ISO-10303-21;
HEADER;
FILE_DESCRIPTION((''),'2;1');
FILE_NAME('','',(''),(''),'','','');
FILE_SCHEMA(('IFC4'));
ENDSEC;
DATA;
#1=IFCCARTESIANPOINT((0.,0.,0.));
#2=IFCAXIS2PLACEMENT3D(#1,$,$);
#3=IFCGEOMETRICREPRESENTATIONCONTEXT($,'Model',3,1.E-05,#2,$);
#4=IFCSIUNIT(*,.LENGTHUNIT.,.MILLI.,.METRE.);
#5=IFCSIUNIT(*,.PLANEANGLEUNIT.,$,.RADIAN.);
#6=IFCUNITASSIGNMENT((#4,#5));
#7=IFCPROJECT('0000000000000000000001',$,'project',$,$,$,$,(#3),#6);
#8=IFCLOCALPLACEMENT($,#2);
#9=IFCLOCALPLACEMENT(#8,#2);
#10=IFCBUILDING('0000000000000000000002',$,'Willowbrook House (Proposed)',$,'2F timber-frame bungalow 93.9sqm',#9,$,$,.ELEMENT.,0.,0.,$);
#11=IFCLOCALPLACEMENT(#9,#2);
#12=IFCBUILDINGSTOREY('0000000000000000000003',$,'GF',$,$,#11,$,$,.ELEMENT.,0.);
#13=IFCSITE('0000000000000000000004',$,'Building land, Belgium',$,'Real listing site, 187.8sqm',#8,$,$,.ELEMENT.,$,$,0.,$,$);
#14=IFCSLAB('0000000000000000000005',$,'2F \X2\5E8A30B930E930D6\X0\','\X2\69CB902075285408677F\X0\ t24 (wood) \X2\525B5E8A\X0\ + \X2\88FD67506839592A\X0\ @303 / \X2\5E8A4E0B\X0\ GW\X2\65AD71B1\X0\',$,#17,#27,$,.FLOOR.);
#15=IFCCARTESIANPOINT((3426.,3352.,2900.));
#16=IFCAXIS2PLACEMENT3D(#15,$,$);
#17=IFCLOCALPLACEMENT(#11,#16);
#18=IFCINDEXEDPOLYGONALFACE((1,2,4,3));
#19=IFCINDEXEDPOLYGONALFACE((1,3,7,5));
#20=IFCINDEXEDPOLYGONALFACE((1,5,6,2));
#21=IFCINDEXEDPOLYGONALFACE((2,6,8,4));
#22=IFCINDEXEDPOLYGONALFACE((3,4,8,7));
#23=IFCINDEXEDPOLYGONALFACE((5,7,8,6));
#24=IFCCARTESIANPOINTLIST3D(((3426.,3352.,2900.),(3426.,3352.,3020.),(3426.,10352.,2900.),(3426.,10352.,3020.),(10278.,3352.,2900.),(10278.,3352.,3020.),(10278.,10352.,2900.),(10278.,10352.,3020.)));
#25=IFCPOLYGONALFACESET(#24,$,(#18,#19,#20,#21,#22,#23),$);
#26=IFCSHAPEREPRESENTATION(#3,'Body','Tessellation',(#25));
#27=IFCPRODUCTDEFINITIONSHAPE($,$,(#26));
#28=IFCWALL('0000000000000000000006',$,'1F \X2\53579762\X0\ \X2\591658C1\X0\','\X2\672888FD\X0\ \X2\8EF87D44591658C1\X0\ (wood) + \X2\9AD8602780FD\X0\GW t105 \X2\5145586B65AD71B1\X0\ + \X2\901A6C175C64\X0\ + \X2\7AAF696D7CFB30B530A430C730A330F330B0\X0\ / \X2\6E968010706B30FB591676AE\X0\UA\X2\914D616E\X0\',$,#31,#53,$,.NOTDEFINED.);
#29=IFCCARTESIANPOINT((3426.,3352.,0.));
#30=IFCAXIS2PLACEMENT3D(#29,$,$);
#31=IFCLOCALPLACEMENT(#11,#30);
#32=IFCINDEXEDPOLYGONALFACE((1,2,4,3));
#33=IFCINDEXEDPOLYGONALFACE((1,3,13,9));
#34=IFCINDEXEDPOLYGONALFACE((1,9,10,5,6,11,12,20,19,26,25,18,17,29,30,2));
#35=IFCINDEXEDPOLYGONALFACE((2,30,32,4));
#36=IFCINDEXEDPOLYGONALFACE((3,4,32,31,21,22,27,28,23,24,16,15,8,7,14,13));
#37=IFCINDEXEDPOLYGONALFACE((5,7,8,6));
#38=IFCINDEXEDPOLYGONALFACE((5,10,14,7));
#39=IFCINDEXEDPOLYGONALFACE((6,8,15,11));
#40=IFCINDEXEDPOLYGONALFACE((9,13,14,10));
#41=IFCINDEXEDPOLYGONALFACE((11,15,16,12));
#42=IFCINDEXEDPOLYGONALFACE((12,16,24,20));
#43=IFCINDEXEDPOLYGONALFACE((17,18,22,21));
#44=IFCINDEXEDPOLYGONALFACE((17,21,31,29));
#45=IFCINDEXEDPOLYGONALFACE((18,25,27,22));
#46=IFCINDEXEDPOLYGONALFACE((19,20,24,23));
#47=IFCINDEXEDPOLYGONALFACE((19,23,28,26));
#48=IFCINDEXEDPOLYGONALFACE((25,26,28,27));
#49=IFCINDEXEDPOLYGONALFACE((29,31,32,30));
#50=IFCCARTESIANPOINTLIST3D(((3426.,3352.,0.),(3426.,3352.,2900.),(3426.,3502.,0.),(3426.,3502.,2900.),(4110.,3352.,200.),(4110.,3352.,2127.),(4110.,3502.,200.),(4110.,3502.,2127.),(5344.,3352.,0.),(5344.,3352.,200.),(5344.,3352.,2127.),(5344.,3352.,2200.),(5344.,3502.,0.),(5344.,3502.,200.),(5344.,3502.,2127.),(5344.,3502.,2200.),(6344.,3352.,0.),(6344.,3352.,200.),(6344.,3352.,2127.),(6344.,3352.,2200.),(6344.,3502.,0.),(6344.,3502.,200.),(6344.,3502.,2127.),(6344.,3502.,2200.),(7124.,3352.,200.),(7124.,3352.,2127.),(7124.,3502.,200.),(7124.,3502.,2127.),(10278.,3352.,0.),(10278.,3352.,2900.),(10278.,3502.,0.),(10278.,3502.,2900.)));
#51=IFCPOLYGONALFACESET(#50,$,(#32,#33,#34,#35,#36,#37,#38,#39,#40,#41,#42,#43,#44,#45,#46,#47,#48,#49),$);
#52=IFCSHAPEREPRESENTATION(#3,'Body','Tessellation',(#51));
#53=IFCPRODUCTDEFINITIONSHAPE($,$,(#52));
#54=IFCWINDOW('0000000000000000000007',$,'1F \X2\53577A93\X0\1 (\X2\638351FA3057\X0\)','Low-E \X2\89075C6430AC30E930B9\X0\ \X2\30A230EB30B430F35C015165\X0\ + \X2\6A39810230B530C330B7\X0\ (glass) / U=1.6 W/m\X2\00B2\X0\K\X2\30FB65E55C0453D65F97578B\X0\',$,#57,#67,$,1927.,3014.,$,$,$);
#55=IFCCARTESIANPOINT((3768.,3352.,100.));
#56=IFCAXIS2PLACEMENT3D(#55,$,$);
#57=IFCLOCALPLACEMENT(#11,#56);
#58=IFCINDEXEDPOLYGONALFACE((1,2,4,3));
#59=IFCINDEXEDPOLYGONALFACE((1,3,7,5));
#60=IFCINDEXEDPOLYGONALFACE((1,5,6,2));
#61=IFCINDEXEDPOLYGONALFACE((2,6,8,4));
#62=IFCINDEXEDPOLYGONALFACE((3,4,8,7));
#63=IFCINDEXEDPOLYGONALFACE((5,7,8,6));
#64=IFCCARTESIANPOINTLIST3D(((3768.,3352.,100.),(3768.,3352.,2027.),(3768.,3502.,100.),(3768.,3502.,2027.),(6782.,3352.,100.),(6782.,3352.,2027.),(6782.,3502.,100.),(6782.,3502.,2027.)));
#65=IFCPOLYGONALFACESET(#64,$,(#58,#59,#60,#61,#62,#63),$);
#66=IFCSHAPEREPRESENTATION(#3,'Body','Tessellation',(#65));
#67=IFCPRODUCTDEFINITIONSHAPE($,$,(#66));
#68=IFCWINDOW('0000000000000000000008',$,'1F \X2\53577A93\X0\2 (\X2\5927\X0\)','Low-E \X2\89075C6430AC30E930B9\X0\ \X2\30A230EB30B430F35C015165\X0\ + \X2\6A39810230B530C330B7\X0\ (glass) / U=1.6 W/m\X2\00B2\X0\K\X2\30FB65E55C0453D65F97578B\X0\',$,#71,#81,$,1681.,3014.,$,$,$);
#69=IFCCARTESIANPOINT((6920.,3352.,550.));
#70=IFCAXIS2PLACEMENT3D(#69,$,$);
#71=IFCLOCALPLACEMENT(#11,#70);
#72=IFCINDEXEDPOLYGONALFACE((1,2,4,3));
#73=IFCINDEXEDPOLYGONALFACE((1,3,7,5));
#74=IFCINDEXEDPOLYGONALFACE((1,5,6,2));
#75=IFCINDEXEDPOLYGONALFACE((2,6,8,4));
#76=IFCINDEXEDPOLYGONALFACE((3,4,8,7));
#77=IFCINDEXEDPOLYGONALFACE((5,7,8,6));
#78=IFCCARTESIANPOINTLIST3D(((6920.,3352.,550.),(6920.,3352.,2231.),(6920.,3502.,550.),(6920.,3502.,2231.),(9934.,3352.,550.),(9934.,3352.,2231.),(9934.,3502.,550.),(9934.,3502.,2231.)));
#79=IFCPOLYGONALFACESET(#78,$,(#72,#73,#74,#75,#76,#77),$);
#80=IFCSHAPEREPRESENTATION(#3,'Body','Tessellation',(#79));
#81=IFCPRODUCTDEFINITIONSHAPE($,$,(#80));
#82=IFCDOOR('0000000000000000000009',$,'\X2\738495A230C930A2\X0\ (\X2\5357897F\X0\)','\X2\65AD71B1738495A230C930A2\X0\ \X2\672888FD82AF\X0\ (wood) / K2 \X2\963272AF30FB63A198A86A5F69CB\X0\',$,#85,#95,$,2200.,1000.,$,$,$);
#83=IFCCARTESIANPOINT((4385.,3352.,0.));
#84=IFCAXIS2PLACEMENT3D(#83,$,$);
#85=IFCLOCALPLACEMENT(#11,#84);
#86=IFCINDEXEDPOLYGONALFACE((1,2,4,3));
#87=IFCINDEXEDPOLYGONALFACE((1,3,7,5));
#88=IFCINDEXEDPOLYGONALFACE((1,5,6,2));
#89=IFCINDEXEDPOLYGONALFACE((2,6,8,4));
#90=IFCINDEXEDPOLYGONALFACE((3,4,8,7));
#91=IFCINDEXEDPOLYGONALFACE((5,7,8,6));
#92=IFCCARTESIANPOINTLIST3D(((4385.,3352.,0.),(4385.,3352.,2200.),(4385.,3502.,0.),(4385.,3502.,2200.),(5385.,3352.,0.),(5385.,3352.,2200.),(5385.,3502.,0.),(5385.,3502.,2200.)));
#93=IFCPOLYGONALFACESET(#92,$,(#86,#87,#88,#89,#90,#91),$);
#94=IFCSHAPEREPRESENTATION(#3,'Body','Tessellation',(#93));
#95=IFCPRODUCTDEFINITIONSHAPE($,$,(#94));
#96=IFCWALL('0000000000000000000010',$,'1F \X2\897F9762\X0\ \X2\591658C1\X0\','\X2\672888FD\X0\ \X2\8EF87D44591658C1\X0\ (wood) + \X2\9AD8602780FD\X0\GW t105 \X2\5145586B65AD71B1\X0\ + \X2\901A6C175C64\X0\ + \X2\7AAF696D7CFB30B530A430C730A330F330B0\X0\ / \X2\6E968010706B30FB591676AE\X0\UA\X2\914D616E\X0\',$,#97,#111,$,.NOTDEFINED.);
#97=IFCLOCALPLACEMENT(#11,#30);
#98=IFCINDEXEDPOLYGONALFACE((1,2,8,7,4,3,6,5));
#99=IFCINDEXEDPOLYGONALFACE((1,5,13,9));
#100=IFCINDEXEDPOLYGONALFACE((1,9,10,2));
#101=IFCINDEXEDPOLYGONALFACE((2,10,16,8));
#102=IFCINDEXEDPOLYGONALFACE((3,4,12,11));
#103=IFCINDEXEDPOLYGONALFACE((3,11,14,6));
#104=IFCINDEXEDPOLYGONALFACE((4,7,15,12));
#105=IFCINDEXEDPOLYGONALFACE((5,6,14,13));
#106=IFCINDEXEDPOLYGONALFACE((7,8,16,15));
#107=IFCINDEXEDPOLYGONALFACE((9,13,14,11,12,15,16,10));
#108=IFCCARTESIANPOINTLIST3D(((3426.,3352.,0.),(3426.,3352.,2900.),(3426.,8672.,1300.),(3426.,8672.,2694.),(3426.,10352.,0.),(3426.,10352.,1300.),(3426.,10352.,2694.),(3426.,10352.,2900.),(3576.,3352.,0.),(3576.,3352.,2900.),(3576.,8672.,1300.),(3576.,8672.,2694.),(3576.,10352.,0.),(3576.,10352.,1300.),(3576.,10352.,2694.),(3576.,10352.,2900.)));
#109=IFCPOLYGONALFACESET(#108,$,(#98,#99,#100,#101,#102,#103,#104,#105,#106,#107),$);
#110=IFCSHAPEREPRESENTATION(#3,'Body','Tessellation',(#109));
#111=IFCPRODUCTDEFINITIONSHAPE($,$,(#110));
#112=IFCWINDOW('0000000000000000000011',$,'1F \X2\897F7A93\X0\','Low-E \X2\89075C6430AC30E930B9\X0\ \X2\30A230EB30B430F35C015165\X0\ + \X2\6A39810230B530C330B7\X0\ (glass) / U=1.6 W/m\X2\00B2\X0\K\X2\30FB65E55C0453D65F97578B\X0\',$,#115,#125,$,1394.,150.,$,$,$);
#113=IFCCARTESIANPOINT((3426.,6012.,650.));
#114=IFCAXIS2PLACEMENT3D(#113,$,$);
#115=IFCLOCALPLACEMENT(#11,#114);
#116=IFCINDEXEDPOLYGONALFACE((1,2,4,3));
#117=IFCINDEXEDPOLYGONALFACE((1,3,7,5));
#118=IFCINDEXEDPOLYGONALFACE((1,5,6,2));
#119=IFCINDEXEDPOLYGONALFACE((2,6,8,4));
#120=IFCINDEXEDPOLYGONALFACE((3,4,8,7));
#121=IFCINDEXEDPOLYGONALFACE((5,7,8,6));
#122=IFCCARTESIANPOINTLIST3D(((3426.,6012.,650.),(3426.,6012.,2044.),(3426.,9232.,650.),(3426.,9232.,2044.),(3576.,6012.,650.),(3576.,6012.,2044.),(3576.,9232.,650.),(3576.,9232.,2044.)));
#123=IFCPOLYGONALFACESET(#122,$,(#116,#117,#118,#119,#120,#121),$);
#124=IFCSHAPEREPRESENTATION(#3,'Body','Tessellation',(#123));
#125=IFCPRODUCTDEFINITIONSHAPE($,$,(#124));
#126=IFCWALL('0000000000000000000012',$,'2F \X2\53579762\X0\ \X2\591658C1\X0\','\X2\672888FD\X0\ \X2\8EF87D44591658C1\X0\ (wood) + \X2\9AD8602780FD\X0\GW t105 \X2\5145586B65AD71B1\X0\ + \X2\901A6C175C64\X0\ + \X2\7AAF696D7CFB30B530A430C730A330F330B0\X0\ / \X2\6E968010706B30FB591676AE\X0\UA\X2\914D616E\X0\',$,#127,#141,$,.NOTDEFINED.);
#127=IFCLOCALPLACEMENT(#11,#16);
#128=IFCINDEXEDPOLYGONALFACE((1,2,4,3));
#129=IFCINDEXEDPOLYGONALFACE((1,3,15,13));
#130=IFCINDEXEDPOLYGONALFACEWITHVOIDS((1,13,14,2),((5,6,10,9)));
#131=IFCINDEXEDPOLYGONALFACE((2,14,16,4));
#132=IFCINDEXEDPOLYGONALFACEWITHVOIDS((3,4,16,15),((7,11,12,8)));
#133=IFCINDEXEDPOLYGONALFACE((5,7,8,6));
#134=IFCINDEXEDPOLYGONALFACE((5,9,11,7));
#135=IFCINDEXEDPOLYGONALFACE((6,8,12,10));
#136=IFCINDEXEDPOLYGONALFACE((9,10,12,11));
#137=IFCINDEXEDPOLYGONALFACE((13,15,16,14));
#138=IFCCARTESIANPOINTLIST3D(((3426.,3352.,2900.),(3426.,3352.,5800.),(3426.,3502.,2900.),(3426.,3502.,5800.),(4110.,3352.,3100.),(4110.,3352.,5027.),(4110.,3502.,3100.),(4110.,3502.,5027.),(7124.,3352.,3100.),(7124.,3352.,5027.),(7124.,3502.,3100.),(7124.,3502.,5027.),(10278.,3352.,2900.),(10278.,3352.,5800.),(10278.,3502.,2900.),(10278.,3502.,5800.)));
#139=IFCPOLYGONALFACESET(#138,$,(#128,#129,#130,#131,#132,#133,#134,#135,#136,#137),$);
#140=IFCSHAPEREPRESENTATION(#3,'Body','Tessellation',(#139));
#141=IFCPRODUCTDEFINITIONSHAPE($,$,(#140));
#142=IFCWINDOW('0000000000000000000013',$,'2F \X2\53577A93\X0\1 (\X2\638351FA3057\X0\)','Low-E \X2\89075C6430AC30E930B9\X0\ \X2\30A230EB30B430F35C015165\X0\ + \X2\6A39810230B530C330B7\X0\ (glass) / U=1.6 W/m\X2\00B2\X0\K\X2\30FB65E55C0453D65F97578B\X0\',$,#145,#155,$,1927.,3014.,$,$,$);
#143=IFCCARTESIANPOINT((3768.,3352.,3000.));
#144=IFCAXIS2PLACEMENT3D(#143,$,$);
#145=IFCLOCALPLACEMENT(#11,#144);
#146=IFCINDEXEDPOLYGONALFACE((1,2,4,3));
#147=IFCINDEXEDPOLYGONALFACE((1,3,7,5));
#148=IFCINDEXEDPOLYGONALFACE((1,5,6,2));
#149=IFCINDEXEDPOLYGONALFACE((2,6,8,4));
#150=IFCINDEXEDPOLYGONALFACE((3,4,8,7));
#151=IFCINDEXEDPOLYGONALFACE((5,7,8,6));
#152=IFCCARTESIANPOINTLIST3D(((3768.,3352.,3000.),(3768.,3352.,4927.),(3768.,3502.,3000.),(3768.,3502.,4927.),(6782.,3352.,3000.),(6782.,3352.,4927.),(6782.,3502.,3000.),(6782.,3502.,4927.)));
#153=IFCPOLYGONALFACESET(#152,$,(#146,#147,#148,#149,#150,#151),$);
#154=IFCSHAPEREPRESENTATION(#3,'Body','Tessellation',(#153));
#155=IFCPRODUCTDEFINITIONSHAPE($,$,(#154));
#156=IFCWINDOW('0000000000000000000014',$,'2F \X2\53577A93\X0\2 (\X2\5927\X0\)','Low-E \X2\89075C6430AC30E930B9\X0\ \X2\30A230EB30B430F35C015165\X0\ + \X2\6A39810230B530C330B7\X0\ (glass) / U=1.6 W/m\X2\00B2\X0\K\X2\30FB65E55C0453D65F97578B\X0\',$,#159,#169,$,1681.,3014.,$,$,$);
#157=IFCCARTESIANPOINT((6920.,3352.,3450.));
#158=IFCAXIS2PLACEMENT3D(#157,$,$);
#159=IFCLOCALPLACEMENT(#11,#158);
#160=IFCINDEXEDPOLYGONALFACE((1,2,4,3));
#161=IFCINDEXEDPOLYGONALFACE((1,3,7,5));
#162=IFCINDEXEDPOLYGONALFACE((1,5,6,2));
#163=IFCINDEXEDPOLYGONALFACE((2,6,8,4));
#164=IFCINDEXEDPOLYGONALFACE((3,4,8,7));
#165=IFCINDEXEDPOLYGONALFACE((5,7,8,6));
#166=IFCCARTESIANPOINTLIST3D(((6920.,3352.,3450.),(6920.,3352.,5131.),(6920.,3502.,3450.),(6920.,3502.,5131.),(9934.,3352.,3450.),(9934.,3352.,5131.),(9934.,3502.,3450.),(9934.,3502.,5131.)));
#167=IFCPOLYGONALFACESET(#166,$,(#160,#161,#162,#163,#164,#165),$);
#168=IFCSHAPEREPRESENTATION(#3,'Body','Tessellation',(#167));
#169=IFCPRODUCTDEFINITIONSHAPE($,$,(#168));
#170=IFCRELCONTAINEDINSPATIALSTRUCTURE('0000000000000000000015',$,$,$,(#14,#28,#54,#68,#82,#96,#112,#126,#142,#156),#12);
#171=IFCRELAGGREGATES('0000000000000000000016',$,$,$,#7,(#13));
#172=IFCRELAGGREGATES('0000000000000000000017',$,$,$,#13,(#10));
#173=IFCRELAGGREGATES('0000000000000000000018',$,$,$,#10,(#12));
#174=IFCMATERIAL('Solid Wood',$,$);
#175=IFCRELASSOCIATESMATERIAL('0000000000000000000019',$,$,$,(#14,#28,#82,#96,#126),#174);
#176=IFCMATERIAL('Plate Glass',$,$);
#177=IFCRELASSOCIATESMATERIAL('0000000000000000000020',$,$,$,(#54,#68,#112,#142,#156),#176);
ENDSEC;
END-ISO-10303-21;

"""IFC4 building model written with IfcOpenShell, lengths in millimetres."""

from ifc_helpers import new_model, si_unit, frame, frame_2d, origin, place, context, project, spatial, rectangle, extrude, material, element, fill, save


model = new_model("IFC4")

# Units and contexts
model_context = context("Model", 3, precision=1e-05, world=origin())
ifc_project = project(units=[si_unit("LENGTHUNIT", "METRE", prefix="MILLI"), si_unit("PLANEANGLEUNIT", "RADIAN")], contexts=[model_context])

# Site, building, storey
site_placement = place(None, origin())
site = spatial("IfcSite", under=ifc_project, at=site_placement, Name="Building land, Belgium", ObjectType="Real listing site, 187.8sqm", CompositionType="ELEMENT", RefElevation=0.0)
building_placement = place(site_placement, origin())
building = spatial("IfcBuilding", under=site, at=building_placement, Name="Willowbrook House (Proposed)", ObjectType="2F timber-frame bungalow 93.9sqm", CompositionType="ELEMENT", ElevationOfRefHeight=0.0, ElevationOfTerrain=0.0)
storey_placement = place(building_placement, origin())
storey = spatial("IfcBuildingStorey", under=building, at=storey_placement, Name="GF", CompositionType="ELEMENT", Elevation=0.0)

# Slab
ifc_material_1 = material(Name="Solid Wood")
slab_1_placement = place(storey_placement, frame((3426.0, 3352.0, 2900.0)))
element("IfcSlab", 1, at=slab_1_placement, inside=storey, material=ifc_material_1, Name="2F 床スラブ", Description="構造用合板 t24 (wood) 剛床 + 製材根太 @303 / 床下 GW断熱", PredefinedType="FLOOR", context=model_context, shape_type="SweptSolid", body=[
    extrude(rectangle(XDim=6852.0, YDim=7000.0, at=frame_2d((3426.0, 3500.0))), frame((3426.0, 3352.0, 2900.0)), (0.0, 0.0, 1.0), 120.0),
])

# Wall, openings, windows, door
wall_1_placement = place(storey_placement, frame((3426.0, 3352.0, 0.0)))
wall_1 = element("IfcWall", 2, at=wall_1_placement, inside=storey, material=ifc_material_1, Name="1F 南面 外壁", Description="木製 軸組外壁 (wood) + 高性能GW t105 充填断熱 + 通気層 + 窯業系サイディング / 準耐火・外皮UA配慮", PredefinedType="NOTDEFINED", context=model_context, shape_type="SweptSolid", body=[
    extrude(rectangle(XDim=6852.0, YDim=150.0, at=frame_2d((3426.0, 75.0))), frame((3426.0, 3352.0, 0.0)), (0.0, 0.0, 1.0), 2900.0),
])
opening_1_placement = place(storey_placement, frame((3768.0, 3352.0, 100.0)))
opening_1 = element("IfcOpeningElement", 3, at=opening_1_placement, cuts=wall_1, PredefinedType="NOTDEFINED", context=model_context, shape_type="SweptSolid", body=[
    extrude(rectangle(XDim=3014.0, YDim=150.0, at=frame_2d((1507.0, 75.0))), frame((3768.0, 3352.0, 100.0)), (0.0, 0.0, 1.0), 1927.0),
])
opening_2_placement = place(storey_placement, frame((6920.0, 3352.0, 550.0)))
opening_2 = element("IfcOpeningElement", 4, at=opening_2_placement, cuts=wall_1, PredefinedType="NOTDEFINED", context=model_context, shape_type="SweptSolid", body=[
    extrude(rectangle(XDim=3014.0, YDim=150.0, at=frame_2d((1507.0, 75.0))), frame((6920.0, 3352.0, 550.0)), (0.0, 0.0, 1.0), 1681.0),
])
opening_3_placement = place(storey_placement, frame((4385.0, 3352.0, 0.0)))
opening_3 = element("IfcOpeningElement", 5, at=opening_3_placement, cuts=wall_1, PredefinedType="NOTDEFINED", context=model_context, shape_type="SweptSolid", body=[
    extrude(rectangle(XDim=1000.0, YDim=150.0, at=frame_2d((500.0, 75.0))), frame((4385.0, 3352.0, 0.0)), (0.0, 0.0, 1.0), 2200.0),
])
ifc_material_2 = material(Name="Plate Glass")
window_1_placement = place(storey_placement, frame((3768.0, 3352.0, 100.0)))
window_1 = element("IfcWindow", 6, at=window_1_placement, inside=storey, material=ifc_material_2, Name="1F 南窓1 (掃出し)", Description="Low-E 複層ガラス アルゴン封入 + 樹脂サッシ (glass) / U=1.6 W/m²K・日射取得型", OverallHeight=1927.0, OverallWidth=3014.0, context=model_context, shape_type="SweptSolid", body=[
    extrude(rectangle(XDim=3014.0, YDim=150.0, at=frame_2d((1507.0, 75.0))), frame((3768.0, 3352.0, 100.0)), (0.0, 0.0, 1.0), 1927.0),
])
fill(opening_1, window_1)
window_2_placement = place(storey_placement, frame((6920.0, 3352.0, 550.0)))
window_2 = element("IfcWindow", 7, at=window_2_placement, inside=storey, material=ifc_material_2, Name="1F 南窓2 (大)", Description="Low-E 複層ガラス アルゴン封入 + 樹脂サッシ (glass) / U=1.6 W/m²K・日射取得型", OverallHeight=1681.0, OverallWidth=3014.0, context=model_context, shape_type="SweptSolid", body=[
    extrude(rectangle(XDim=3014.0, YDim=150.0, at=frame_2d((1507.0, 75.0))), frame((6920.0, 3352.0, 550.0)), (0.0, 0.0, 1.0), 1681.0),
])
fill(opening_2, window_2)
door_placement = place(storey_placement, frame((4385.0, 3352.0, 0.0)))
door = element("IfcDoor", 8, at=door_placement, inside=storey, material=ifc_material_1, Name="玄関ドア (南西)", Description="断熱玄関ドア 木製芯 (wood) / K2 防犯・採風機構", OverallHeight=2200.0, OverallWidth=1000.0, context=model_context, shape_type="SweptSolid", body=[
    extrude(rectangle(XDim=1000.0, YDim=150.0, at=frame_2d((500.0, 75.0))), frame((4385.0, 3352.0, 0.0)), (0.0, 0.0, 1.0), 2200.0),
])
fill(opening_3, door)

# Wall, opening, window
wall_2_placement = place(storey_placement, frame((3426.0, 3352.0, 0.0)))
wall_2 = element("IfcWall", 9, at=wall_2_placement, inside=storey, material=ifc_material_1, Name="1F 西面 外壁", Description="木製 軸組外壁 (wood) + 高性能GW t105 充填断熱 + 通気層 + 窯業系サイディング / 準耐火・外皮UA配慮", PredefinedType="NOTDEFINED", context=model_context, shape_type="SweptSolid", body=[
    extrude(rectangle(XDim=150.0, YDim=7000.0, at=frame_2d((75.0, 3500.0))), frame((3426.0, 3352.0, 0.0)), (0.0, 0.0, 1.0), 2900.0),
])
opening_4_placement = place(storey_placement, frame((3426.0, 6012.0, 650.0)))
opening_4 = element("IfcOpeningElement", 10, at=opening_4_placement, cuts=wall_2, PredefinedType="NOTDEFINED", context=model_context, shape_type="SweptSolid", body=[
    extrude(rectangle(XDim=150.0, YDim=3220.0, at=frame_2d((75.0, 1610.0))), frame((3426.0, 6012.0, 650.0)), (0.0, 0.0, 1.0), 1394.0),
])
window_3_placement = place(storey_placement, frame((3426.0, 6012.0, 650.0)))
window_3 = element("IfcWindow", 11, at=window_3_placement, inside=storey, material=ifc_material_2, Name="1F 西窓", Description="Low-E 複層ガラス アルゴン封入 + 樹脂サッシ (glass) / U=1.6 W/m²K・日射取得型", OverallHeight=1394.0, OverallWidth=150.0, context=model_context, shape_type="SweptSolid", body=[
    extrude(rectangle(XDim=150.0, YDim=3220.0, at=frame_2d((75.0, 1610.0))), frame((3426.0, 6012.0, 650.0)), (0.0, 0.0, 1.0), 1394.0),
])
fill(opening_4, window_3)

# Wall, openings, windows
wall_3_placement = place(storey_placement, frame((3426.0, 3352.0, 2900.0)))
wall_3 = element("IfcWall", 12, at=wall_3_placement, inside=storey, material=ifc_material_1, Name="2F 南面 外壁", Description="木製 軸組外壁 (wood) + 高性能GW t105 充填断熱 + 通気層 + 窯業系サイディング / 準耐火・外皮UA配慮", PredefinedType="NOTDEFINED", context=model_context, shape_type="SweptSolid", body=[
    extrude(rectangle(XDim=6852.0, YDim=150.0, at=frame_2d((3426.0, 75.0))), frame((3426.0, 3352.0, 2900.0)), (0.0, 0.0, 1.0), 2900.0),
])
opening_5_placement = place(storey_placement, frame((3768.0, 3352.0, 3000.0)))
opening_5 = element("IfcOpeningElement", 13, at=opening_5_placement, cuts=wall_3, PredefinedType="NOTDEFINED", context=model_context, shape_type="SweptSolid", body=[
    extrude(rectangle(XDim=3014.0, YDim=150.0, at=frame_2d((1507.0, 75.0))), frame((3768.0, 3352.0, 3000.0)), (0.0, 0.0, 1.0), 1927.0),
])
opening_6_placement = place(storey_placement, frame((6920.0, 3352.0, 3450.0)))
opening_6 = element("IfcOpeningElement", 14, at=opening_6_placement, cuts=wall_3, PredefinedType="NOTDEFINED", context=model_context, shape_type="SweptSolid", body=[
    extrude(rectangle(XDim=3014.0, YDim=150.0, at=frame_2d((1507.0, 75.0))), frame((6920.0, 3352.0, 3450.0)), (0.0, 0.0, 1.0), 1681.0),
])
window_4_placement = place(storey_placement, frame((3768.0, 3352.0, 3000.0)))
window_4 = element("IfcWindow", 15, at=window_4_placement, inside=storey, material=ifc_material_2, Name="2F 南窓1 (掃出し)", Description="Low-E 複層ガラス アルゴン封入 + 樹脂サッシ (glass) / U=1.6 W/m²K・日射取得型", OverallHeight=1927.0, OverallWidth=3014.0, context=model_context, shape_type="SweptSolid", body=[
    extrude(rectangle(XDim=3014.0, YDim=150.0, at=frame_2d((1507.0, 75.0))), frame((3768.0, 3352.0, 3000.0)), (0.0, 0.0, 1.0), 1927.0),
])
fill(opening_5, window_4)
window_5_placement = place(storey_placement, frame((6920.0, 3352.0, 3450.0)))
window_5 = element("IfcWindow", 16, at=window_5_placement, inside=storey, material=ifc_material_2, Name="2F 南窓2 (大)", Description="Low-E 複層ガラス アルゴン封入 + 樹脂サッシ (glass) / U=1.6 W/m²K・日射取得型", OverallHeight=1681.0, OverallWidth=3014.0, context=model_context, shape_type="SweptSolid", body=[
    extrude(rectangle(XDim=3014.0, YDim=150.0, at=frame_2d((1507.0, 75.0))), frame((6920.0, 3352.0, 3450.0)), (0.0, 0.0, 1.0), 1681.0),
])
fill(opening_6, window_5)

save(model, "model.ifc")
